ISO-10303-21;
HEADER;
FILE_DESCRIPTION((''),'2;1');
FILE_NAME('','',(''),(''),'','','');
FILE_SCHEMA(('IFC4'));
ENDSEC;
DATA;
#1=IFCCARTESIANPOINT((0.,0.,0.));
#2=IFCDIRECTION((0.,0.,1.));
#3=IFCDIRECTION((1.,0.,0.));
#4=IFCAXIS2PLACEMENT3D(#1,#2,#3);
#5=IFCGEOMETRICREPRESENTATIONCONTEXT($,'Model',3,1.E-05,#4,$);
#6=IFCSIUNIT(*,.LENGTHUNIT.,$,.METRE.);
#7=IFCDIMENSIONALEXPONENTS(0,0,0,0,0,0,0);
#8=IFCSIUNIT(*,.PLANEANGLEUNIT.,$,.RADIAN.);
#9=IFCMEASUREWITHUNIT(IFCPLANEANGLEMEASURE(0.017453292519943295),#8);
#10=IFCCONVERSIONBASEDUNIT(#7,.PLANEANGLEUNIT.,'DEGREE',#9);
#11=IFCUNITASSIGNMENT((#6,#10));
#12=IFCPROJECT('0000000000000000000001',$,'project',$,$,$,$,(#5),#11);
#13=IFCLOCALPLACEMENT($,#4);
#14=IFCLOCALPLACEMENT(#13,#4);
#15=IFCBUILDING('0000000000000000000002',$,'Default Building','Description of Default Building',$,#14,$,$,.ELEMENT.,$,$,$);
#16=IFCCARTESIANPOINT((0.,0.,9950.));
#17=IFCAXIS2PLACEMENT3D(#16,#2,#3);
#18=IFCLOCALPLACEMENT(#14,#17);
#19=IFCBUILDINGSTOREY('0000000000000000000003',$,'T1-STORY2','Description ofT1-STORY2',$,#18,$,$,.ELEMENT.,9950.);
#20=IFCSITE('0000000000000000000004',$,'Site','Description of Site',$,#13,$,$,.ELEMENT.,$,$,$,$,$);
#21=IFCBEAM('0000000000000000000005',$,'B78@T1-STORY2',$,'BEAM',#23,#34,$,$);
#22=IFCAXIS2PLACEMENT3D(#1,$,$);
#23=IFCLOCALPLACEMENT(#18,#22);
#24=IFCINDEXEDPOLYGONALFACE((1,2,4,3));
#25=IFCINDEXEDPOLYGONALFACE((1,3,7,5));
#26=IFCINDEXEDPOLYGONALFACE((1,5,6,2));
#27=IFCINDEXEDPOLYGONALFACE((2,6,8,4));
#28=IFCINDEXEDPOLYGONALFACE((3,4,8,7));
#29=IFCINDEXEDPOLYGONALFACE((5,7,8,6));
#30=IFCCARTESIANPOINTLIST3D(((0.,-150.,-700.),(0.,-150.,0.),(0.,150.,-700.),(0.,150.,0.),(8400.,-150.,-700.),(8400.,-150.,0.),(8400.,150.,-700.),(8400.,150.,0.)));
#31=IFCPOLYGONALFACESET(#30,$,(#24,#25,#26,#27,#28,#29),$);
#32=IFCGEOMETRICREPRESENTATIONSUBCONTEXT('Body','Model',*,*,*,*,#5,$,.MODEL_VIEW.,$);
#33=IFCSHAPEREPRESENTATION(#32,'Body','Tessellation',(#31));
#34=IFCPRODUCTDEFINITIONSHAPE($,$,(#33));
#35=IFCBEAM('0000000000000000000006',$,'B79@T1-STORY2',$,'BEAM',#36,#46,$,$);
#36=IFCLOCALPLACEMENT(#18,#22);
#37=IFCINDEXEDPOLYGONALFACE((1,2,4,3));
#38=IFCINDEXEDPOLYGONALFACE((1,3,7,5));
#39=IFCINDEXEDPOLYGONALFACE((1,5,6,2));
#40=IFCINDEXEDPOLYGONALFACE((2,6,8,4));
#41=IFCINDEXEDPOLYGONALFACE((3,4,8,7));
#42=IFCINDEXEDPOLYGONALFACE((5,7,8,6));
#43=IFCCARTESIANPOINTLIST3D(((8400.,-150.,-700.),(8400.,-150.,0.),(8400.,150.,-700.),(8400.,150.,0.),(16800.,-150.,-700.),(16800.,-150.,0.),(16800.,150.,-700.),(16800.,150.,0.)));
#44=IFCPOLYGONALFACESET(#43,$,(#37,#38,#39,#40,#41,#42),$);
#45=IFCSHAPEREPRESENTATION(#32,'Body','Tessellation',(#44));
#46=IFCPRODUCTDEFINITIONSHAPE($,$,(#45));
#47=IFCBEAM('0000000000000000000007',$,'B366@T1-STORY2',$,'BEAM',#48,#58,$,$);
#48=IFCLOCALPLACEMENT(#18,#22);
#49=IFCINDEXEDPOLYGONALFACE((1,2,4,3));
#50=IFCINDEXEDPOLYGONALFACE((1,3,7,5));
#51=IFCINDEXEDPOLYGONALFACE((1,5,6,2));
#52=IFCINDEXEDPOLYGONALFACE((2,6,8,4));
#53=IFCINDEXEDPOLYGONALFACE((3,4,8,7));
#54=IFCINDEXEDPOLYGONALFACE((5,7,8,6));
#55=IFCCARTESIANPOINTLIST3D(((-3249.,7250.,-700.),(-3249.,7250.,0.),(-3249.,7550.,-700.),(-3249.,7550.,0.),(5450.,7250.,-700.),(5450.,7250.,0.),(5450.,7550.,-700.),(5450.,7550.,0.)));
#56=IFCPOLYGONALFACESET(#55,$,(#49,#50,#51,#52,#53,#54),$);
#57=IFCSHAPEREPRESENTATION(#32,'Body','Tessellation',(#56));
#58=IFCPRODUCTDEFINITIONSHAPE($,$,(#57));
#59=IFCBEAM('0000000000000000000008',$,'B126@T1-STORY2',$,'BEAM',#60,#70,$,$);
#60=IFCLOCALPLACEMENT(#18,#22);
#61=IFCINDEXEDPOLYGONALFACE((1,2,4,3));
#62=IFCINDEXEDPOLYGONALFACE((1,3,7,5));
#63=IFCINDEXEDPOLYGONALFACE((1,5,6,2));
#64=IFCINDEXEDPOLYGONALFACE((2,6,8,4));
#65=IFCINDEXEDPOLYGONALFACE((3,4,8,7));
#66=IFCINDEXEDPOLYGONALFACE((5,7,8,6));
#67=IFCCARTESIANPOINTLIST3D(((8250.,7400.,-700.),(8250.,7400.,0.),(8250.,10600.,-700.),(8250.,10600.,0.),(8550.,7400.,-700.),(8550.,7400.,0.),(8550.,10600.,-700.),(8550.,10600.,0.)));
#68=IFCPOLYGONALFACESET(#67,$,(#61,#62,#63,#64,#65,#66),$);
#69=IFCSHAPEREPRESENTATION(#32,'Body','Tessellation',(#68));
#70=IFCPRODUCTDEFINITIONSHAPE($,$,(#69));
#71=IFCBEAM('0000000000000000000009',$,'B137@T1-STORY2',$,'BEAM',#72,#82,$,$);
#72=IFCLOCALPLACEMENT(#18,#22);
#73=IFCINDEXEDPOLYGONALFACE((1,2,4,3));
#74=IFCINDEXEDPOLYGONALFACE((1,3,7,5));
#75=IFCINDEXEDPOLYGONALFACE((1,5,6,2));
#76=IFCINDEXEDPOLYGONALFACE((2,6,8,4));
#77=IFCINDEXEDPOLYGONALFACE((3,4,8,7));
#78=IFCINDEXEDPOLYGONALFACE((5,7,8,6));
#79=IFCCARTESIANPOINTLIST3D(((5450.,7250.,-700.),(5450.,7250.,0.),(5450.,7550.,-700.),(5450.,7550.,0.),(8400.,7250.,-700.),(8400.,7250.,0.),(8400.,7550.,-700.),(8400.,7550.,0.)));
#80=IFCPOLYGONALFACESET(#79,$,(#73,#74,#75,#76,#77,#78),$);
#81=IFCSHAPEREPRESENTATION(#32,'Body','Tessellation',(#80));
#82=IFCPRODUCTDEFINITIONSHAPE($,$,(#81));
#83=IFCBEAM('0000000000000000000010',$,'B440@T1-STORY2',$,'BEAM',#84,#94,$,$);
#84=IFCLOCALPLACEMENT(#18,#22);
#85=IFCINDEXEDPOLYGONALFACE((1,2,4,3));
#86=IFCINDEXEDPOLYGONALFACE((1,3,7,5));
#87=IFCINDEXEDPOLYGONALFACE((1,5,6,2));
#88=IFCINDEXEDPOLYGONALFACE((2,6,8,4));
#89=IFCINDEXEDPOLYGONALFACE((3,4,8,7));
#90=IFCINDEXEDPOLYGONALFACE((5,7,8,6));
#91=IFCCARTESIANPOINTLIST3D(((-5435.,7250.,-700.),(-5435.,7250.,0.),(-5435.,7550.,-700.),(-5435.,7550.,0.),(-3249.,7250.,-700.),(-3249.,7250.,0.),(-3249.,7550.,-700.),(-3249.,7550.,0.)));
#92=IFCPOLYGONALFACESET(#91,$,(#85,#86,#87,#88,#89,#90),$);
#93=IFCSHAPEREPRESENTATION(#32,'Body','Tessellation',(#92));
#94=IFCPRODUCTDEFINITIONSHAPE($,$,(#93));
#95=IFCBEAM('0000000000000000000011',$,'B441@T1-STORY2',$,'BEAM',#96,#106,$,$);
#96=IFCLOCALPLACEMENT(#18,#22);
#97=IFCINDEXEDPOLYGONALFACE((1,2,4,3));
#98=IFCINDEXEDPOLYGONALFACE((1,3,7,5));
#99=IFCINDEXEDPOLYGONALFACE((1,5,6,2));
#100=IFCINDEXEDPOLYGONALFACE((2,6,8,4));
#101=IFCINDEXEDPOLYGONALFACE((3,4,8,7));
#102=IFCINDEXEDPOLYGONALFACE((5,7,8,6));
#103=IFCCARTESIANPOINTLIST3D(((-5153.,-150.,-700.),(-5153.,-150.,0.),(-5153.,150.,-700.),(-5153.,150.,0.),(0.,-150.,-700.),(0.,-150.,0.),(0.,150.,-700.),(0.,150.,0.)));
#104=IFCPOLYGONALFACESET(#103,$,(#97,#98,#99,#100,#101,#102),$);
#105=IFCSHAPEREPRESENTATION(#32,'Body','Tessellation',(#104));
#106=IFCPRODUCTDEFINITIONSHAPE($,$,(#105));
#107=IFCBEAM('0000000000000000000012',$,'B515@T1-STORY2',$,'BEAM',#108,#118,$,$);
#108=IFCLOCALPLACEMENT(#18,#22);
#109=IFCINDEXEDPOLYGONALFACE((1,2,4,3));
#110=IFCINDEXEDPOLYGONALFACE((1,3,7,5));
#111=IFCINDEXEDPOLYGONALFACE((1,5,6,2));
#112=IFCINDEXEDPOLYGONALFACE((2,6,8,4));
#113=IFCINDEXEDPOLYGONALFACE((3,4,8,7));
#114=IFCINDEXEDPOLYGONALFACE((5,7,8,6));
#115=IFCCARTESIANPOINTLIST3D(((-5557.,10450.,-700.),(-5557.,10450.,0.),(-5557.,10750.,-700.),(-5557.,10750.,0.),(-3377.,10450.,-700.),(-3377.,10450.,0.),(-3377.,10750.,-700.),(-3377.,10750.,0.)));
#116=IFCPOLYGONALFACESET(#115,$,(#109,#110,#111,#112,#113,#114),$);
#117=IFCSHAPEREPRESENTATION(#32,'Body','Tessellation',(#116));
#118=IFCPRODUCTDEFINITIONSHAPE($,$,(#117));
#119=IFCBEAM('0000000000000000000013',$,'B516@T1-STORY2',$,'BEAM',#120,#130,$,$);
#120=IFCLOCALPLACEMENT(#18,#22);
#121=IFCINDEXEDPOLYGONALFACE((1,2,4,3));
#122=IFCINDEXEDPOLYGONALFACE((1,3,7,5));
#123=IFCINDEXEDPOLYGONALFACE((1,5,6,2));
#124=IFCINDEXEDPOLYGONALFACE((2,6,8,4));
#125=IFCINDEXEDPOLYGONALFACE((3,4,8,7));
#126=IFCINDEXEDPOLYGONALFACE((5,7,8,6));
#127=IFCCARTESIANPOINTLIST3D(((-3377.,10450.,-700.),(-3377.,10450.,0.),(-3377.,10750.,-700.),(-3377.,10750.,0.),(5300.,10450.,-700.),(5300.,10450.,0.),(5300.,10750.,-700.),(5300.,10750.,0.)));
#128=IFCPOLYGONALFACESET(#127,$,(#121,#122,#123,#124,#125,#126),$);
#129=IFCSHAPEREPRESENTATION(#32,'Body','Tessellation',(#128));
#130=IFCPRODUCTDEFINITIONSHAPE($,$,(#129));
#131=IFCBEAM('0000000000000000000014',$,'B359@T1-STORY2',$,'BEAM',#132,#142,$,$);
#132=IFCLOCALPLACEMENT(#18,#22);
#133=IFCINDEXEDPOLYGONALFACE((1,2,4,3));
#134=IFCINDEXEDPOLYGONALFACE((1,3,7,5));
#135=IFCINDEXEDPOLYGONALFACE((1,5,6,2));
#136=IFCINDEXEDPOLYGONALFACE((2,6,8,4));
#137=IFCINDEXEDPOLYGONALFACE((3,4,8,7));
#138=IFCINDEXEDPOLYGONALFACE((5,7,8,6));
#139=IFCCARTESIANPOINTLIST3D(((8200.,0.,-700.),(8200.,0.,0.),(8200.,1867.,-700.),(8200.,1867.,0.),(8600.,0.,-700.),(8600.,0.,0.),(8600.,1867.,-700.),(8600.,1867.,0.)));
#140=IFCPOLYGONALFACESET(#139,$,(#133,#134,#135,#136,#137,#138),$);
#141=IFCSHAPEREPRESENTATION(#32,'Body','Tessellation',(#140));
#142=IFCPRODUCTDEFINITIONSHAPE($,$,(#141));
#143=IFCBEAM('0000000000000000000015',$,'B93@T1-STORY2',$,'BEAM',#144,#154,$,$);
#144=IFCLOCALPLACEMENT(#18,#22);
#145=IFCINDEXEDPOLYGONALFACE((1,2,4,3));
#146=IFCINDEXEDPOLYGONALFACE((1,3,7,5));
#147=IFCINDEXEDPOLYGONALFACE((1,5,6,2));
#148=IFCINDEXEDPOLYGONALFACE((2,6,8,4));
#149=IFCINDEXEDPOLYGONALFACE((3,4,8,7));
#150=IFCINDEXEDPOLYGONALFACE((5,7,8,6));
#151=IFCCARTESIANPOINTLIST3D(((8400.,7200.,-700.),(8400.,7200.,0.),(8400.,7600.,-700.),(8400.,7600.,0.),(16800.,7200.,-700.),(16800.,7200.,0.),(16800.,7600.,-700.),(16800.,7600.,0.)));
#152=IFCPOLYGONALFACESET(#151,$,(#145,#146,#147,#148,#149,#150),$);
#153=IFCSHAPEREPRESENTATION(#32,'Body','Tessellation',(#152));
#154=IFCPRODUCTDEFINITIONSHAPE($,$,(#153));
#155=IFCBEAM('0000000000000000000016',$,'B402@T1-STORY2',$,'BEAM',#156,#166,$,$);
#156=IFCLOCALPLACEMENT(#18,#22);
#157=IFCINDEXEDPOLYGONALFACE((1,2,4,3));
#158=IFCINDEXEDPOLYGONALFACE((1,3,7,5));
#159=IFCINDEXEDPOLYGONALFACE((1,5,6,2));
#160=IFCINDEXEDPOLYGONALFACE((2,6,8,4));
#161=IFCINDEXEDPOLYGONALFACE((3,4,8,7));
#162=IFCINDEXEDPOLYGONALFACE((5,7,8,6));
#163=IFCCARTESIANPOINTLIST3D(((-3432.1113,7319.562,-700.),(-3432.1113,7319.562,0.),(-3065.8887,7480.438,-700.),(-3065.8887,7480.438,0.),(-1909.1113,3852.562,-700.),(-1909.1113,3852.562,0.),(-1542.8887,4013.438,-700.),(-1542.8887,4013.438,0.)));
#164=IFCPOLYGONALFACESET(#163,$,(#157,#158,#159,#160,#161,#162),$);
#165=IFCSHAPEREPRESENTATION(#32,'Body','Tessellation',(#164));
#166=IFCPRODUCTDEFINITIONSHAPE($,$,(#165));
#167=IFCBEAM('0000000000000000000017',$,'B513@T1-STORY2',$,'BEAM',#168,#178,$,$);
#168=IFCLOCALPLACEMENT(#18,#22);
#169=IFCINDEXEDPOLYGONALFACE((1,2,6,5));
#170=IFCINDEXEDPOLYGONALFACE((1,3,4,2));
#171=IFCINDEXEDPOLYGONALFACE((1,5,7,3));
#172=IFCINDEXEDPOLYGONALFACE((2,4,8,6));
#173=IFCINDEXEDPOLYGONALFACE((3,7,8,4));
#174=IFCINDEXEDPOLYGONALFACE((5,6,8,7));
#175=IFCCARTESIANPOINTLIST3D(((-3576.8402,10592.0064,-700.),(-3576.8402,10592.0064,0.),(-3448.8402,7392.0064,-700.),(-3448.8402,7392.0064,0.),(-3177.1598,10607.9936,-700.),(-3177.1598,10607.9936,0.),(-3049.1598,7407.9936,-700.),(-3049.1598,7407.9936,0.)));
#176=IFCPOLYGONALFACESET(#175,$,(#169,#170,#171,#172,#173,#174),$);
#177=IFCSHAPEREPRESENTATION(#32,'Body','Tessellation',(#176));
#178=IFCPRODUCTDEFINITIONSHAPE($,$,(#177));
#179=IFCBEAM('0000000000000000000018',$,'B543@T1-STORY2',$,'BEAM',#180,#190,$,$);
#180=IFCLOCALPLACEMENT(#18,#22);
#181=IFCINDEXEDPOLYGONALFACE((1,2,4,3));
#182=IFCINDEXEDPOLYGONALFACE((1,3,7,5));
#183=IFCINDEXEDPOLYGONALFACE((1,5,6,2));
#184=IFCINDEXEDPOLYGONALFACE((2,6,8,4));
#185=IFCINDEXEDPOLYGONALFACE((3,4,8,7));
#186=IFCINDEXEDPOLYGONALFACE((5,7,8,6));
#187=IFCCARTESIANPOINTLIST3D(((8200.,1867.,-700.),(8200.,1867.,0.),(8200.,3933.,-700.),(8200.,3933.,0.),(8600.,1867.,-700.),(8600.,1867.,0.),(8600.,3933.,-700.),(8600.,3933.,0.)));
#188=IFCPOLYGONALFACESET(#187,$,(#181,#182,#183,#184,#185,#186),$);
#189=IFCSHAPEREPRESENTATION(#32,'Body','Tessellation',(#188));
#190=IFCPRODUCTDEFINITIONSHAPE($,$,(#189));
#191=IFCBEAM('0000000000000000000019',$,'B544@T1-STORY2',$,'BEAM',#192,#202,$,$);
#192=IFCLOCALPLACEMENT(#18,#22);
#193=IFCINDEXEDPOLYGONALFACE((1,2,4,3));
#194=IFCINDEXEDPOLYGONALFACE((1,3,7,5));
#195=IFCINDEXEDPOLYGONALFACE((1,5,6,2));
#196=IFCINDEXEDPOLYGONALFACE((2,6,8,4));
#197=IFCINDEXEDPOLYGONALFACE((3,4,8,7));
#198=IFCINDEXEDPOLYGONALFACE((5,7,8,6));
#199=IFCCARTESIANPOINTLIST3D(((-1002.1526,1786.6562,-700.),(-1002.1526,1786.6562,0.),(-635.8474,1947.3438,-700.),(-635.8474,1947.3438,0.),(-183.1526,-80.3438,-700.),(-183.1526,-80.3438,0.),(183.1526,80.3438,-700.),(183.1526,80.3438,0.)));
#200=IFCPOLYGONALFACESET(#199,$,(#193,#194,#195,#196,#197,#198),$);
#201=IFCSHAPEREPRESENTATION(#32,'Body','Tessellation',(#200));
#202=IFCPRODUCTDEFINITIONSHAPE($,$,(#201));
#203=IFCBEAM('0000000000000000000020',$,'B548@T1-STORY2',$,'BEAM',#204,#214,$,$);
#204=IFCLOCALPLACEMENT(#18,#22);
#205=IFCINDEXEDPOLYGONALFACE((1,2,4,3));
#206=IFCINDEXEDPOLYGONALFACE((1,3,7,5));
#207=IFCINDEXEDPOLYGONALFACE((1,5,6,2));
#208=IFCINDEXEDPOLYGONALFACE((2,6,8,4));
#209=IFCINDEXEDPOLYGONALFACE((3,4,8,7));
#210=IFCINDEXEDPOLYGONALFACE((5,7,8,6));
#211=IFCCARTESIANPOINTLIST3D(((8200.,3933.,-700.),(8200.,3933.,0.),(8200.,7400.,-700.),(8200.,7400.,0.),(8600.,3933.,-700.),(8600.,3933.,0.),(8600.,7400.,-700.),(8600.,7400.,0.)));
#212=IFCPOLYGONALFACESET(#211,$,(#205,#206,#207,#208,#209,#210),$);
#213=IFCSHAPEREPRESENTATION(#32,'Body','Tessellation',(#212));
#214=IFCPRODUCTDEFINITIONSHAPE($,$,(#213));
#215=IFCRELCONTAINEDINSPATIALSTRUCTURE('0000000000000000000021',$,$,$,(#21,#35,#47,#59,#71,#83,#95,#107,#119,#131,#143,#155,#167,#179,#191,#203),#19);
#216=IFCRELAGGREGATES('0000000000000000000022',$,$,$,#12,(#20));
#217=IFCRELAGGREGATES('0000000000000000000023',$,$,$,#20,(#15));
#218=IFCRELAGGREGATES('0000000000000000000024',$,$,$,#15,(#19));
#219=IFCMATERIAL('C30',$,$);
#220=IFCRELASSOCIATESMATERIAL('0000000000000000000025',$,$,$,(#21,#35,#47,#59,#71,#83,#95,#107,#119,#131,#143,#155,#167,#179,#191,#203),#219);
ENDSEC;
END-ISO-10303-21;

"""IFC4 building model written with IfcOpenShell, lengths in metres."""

from ifc_helpers import new_model, entity, si_unit, converted_unit, frame, origin_with_axes, place, context, subcontext, project, spatial, rectangle, extrude, material, element, save


model = new_model("IFC4")

# Units and contexts
model_context = context("Model", 3, precision=1e-05, world=origin_with_axes())
body_context = subcontext(model_context, "Body", "Model", "MODEL_VIEW")
ifc_project = project(units=[si_unit("LENGTHUNIT", "METRE"), converted_unit("PLANEANGLEUNIT", "DEGREE", entity("IfcPlaneAngleMeasure", 0.017453292519943295), si_unit("PLANEANGLEUNIT", "RADIAN"), dimensions=[0, 0, 0, 0, 0, 0, 0])], contexts=[model_context])

# Site, building, storey
site_placement = place(None, origin_with_axes())
site = spatial("IfcSite", under=ifc_project, at=site_placement, Name="Site", Description="Description of Site", CompositionType="ELEMENT")
building_placement = place(site_placement, origin_with_axes())
building = spatial("IfcBuilding", under=site, at=building_placement, Name="Default Building", Description="Description of Default Building", CompositionType="ELEMENT")
storey_placement = place(building_placement, frame((0.0, 0.0, 9950.0), z_axis=(0.0, 0.0, 1.0), x_axis=(1.0, 0.0, 0.0)))
storey = spatial("IfcBuildingStorey", under=building, at=storey_placement, Name="T1-STORY2", Description="Description ofT1-STORY2", CompositionType="ELEMENT", Elevation=9950.0)

# Beams
ifc_material_1 = material(Name="C30")
for number, where, z_axis, x_axis, name in (
    (1, (0.0, 0.0, -350.0), (1.0, 0.0, 0.0), (0.0, 1.0, 0.0), "B78@T1-STORY2"),
    (2, (8400.0, 0.0, -350.0), (1.0, 0.0, 0.0), (0.0, 1.0, 0.0), "B79@T1-STORY2"),
):
    element("IfcBeam", number, at=place(storey_placement, frame(where, z_axis=z_axis, x_axis=x_axis)), inside=storey, material=ifc_material_1, Name=name, ObjectType="BEAM", context=body_context, shape_type="SweptSolid", body=[
        extrude(rectangle(XDim=300.0, YDim=700.0), origin_with_axes(), (0.0, 0.0, 1.0), 8400.0),
    ])
beam_1_placement = place(storey_placement, frame((-3249.0, 7400.0, -350.0), z_axis=(1.0, 0.0, 0.0), x_axis=(0.0, 1.0, 0.0)))
element("IfcBeam", 3, at=beam_1_placement, inside=storey, material=ifc_material_1, Name="B366@T1-STORY2", ObjectType="BEAM", context=body_context, shape_type="SweptSolid", body=[
    extrude(rectangle(XDim=300.0, YDim=700.0), origin_with_axes(), (0.0, 0.0, 1.0), 8699.0),
])
beam_2_placement = place(storey_placement, frame((8400.0, 7400.0, -350.0), z_axis=(0.0, 1.0, 0.0), x_axis=(-1.0, 0.0, 0.0)))
element("IfcBeam", 4, at=beam_2_placement, inside=storey, material=ifc_material_1, Name="B126@T1-STORY2", ObjectType="BEAM", context=body_context, shape_type="SweptSolid", body=[
    extrude(rectangle(XDim=300.0, YDim=700.0), origin_with_axes(), (0.0, 0.0, 1.0), 3200.0),
])
beam_3_placement = place(storey_placement, frame((5450.0, 7400.0, -350.0), z_axis=(1.0, 0.0, 0.0), x_axis=(0.0, 1.0, 0.0)))
element("IfcBeam", 5, at=beam_3_placement, inside=storey, material=ifc_material_1, Name="B137@T1-STORY2", ObjectType="BEAM", context=body_context, shape_type="SweptSolid", body=[
    extrude(rectangle(XDim=300.0, YDim=700.0), origin_with_axes(), (0.0, 0.0, 1.0), 2950.0),
])
beam_4_placement = place(storey_placement, frame((-5435.0, 7400.0, -350.0), z_axis=(1.0, 0.0, 0.0), x_axis=(0.0, 1.0, 0.0)))
element("IfcBeam", 6, at=beam_4_placement, inside=storey, material=ifc_material_1, Name="B440@T1-STORY2", ObjectType="BEAM", context=body_context, shape_type="SweptSolid", body=[
    extrude(rectangle(XDim=300.0, YDim=700.0), origin_with_axes(), (0.0, 0.0, 1.0), 2186.0),
])
beam_5_placement = place(storey_placement, frame((-5153.0, 0.0, -350.0), z_axis=(1.0, 0.0, 0.0), x_axis=(0.0, 1.0, 0.0)))
element("IfcBeam", 7, at=beam_5_placement, inside=storey, material=ifc_material_1, Name="B441@T1-STORY2", ObjectType="BEAM", context=body_context, shape_type="SweptSolid", body=[
    extrude(rectangle(XDim=300.0, YDim=700.0), origin_with_axes(), (0.0, 0.0, 1.0), 5153.0),
])
beam_6_placement = place(storey_placement, frame((-5557.0, 10600.0, -350.0), z_axis=(1.0, 0.0, 0.0), x_axis=(0.0, 1.0, 0.0)))
element("IfcBeam", 8, at=beam_6_placement, inside=storey, material=ifc_material_1, Name="B515@T1-STORY2", ObjectType="BEAM", context=body_context, shape_type="SweptSolid", body=[
    extrude(rectangle(XDim=300.0, YDim=700.0), origin_with_axes(), (0.0, 0.0, 1.0), 2180.0),
])
beam_7_placement = place(storey_placement, frame((-3377.0, 10600.0, -350.0), z_axis=(1.0, 0.0, 0.0), x_axis=(0.0, 1.0, 0.0)))
element("IfcBeam", 9, at=beam_7_placement, inside=storey, material=ifc_material_1, Name="B516@T1-STORY2", ObjectType="BEAM", context=body_context, shape_type="SweptSolid", body=[
    extrude(rectangle(XDim=300.0, YDim=700.0), origin_with_axes(), (0.0, 0.0, 1.0), 8677.0),
])
beam_8_placement = place(storey_placement, frame((8400.0, 0.0, -350.0), z_axis=(0.0, 1.0, 0.0), x_axis=(-1.0, 0.0, 0.0)))
element("IfcBeam", 10, at=beam_8_placement, inside=storey, material=ifc_material_1, Name="B359@T1-STORY2", ObjectType="BEAM", context=body_context, shape_type="SweptSolid", body=[
    extrude(rectangle(XDim=400.0, YDim=700.0), origin_with_axes(), (0.0, 0.0, 1.0), 1867.0),
])
beam_9_placement = place(storey_placement, frame((8400.0, 7400.0, -350.0), z_axis=(1.0, 0.0, 0.0), x_axis=(0.0, 1.0, 0.0)))
element("IfcBeam", 11, at=beam_9_placement, inside=storey, material=ifc_material_1, Name="B93@T1-STORY2", ObjectType="BEAM", context=body_context, shape_type="SweptSolid", body=[
    extrude(rectangle(XDim=400.0, YDim=700.0), origin_with_axes(), (0.0, 0.0, 1.0), 8400.0),
])
beam_10_placement = place(storey_placement, frame((-3249.0, 7400.0, -350.0), z_axis=(0.40219, -0.915556, 0.0), x_axis=(0.915556, 0.40219, 0.0)))
element("IfcBeam", 12, at=beam_10_placement, inside=storey, material=ifc_material_1, Name="B402@T1-STORY2", ObjectType="BEAM", context=body_context, shape_type="SweptSolid", body=[
    extrude(rectangle(XDim=400.0, YDim=700.0), origin_with_axes(), (0.0, 0.0, 1.0), 3786.7688),
])
beam_11_placement = place(storey_placement, frame((-3377.0, 10600.0, -350.0), z_axis=(0.039968, -0.999201, 0.0), x_axis=(0.999201, 0.039968, 0.0)))
element("IfcBeam", 13, at=beam_11_placement, inside=storey, material=ifc_material_1, Name="B513@T1-STORY2", ObjectType="BEAM", context=body_context, shape_type="SweptSolid", body=[
    extrude(rectangle(XDim=400.0, YDim=700.0), origin_with_axes(), (0.0, 0.0, 1.0), 3202.559),
])
beam_12_placement = place(storey_placement, frame((8400.0, 1867.0, -350.0), z_axis=(0.0, 1.0, 0.0), x_axis=(-1.0, 0.0, 0.0)))
element("IfcBeam", 14, at=beam_12_placement, inside=storey, material=ifc_material_1, Name="B543@T1-STORY2", ObjectType="BEAM", context=body_context, shape_type="SweptSolid", body=[
    extrude(rectangle(XDim=400.0, YDim=700.0), origin_with_axes(), (0.0, 0.0, 1.0), 2066.0),
])
beam_13_placement = place(storey_placement, frame((-819.0, 1867.0, -350.0), z_axis=(0.401719, -0.915763, 0.0), x_axis=(0.915763, 0.401719, 0.0)))
element("IfcBeam", 15, at=beam_13_placement, inside=storey, material=ifc_material_1, Name="B544@T1-STORY2", ObjectType="BEAM", context=body_context, shape_type="SweptSolid", body=[
    extrude(rectangle(XDim=400.0, YDim=700.0), origin_with_axes(), (0.0, 0.0, 1.0), 2038.7374),
])
beam_14_placement = place(storey_placement, frame((8400.0, 3933.0, -350.0), z_axis=(0.0, 1.0, 0.0), x_axis=(-1.0, 0.0, 0.0)))
element("IfcBeam", 16, at=beam_14_placement, inside=storey, material=ifc_material_1, Name="B548@T1-STORY2", ObjectType="BEAM", context=body_context, shape_type="SweptSolid", body=[
    extrude(rectangle(XDim=400.0, YDim=700.0), origin_with_axes(), (0.0, 0.0, 1.0), 3467.0),
])

save(model, "model.ifc")
